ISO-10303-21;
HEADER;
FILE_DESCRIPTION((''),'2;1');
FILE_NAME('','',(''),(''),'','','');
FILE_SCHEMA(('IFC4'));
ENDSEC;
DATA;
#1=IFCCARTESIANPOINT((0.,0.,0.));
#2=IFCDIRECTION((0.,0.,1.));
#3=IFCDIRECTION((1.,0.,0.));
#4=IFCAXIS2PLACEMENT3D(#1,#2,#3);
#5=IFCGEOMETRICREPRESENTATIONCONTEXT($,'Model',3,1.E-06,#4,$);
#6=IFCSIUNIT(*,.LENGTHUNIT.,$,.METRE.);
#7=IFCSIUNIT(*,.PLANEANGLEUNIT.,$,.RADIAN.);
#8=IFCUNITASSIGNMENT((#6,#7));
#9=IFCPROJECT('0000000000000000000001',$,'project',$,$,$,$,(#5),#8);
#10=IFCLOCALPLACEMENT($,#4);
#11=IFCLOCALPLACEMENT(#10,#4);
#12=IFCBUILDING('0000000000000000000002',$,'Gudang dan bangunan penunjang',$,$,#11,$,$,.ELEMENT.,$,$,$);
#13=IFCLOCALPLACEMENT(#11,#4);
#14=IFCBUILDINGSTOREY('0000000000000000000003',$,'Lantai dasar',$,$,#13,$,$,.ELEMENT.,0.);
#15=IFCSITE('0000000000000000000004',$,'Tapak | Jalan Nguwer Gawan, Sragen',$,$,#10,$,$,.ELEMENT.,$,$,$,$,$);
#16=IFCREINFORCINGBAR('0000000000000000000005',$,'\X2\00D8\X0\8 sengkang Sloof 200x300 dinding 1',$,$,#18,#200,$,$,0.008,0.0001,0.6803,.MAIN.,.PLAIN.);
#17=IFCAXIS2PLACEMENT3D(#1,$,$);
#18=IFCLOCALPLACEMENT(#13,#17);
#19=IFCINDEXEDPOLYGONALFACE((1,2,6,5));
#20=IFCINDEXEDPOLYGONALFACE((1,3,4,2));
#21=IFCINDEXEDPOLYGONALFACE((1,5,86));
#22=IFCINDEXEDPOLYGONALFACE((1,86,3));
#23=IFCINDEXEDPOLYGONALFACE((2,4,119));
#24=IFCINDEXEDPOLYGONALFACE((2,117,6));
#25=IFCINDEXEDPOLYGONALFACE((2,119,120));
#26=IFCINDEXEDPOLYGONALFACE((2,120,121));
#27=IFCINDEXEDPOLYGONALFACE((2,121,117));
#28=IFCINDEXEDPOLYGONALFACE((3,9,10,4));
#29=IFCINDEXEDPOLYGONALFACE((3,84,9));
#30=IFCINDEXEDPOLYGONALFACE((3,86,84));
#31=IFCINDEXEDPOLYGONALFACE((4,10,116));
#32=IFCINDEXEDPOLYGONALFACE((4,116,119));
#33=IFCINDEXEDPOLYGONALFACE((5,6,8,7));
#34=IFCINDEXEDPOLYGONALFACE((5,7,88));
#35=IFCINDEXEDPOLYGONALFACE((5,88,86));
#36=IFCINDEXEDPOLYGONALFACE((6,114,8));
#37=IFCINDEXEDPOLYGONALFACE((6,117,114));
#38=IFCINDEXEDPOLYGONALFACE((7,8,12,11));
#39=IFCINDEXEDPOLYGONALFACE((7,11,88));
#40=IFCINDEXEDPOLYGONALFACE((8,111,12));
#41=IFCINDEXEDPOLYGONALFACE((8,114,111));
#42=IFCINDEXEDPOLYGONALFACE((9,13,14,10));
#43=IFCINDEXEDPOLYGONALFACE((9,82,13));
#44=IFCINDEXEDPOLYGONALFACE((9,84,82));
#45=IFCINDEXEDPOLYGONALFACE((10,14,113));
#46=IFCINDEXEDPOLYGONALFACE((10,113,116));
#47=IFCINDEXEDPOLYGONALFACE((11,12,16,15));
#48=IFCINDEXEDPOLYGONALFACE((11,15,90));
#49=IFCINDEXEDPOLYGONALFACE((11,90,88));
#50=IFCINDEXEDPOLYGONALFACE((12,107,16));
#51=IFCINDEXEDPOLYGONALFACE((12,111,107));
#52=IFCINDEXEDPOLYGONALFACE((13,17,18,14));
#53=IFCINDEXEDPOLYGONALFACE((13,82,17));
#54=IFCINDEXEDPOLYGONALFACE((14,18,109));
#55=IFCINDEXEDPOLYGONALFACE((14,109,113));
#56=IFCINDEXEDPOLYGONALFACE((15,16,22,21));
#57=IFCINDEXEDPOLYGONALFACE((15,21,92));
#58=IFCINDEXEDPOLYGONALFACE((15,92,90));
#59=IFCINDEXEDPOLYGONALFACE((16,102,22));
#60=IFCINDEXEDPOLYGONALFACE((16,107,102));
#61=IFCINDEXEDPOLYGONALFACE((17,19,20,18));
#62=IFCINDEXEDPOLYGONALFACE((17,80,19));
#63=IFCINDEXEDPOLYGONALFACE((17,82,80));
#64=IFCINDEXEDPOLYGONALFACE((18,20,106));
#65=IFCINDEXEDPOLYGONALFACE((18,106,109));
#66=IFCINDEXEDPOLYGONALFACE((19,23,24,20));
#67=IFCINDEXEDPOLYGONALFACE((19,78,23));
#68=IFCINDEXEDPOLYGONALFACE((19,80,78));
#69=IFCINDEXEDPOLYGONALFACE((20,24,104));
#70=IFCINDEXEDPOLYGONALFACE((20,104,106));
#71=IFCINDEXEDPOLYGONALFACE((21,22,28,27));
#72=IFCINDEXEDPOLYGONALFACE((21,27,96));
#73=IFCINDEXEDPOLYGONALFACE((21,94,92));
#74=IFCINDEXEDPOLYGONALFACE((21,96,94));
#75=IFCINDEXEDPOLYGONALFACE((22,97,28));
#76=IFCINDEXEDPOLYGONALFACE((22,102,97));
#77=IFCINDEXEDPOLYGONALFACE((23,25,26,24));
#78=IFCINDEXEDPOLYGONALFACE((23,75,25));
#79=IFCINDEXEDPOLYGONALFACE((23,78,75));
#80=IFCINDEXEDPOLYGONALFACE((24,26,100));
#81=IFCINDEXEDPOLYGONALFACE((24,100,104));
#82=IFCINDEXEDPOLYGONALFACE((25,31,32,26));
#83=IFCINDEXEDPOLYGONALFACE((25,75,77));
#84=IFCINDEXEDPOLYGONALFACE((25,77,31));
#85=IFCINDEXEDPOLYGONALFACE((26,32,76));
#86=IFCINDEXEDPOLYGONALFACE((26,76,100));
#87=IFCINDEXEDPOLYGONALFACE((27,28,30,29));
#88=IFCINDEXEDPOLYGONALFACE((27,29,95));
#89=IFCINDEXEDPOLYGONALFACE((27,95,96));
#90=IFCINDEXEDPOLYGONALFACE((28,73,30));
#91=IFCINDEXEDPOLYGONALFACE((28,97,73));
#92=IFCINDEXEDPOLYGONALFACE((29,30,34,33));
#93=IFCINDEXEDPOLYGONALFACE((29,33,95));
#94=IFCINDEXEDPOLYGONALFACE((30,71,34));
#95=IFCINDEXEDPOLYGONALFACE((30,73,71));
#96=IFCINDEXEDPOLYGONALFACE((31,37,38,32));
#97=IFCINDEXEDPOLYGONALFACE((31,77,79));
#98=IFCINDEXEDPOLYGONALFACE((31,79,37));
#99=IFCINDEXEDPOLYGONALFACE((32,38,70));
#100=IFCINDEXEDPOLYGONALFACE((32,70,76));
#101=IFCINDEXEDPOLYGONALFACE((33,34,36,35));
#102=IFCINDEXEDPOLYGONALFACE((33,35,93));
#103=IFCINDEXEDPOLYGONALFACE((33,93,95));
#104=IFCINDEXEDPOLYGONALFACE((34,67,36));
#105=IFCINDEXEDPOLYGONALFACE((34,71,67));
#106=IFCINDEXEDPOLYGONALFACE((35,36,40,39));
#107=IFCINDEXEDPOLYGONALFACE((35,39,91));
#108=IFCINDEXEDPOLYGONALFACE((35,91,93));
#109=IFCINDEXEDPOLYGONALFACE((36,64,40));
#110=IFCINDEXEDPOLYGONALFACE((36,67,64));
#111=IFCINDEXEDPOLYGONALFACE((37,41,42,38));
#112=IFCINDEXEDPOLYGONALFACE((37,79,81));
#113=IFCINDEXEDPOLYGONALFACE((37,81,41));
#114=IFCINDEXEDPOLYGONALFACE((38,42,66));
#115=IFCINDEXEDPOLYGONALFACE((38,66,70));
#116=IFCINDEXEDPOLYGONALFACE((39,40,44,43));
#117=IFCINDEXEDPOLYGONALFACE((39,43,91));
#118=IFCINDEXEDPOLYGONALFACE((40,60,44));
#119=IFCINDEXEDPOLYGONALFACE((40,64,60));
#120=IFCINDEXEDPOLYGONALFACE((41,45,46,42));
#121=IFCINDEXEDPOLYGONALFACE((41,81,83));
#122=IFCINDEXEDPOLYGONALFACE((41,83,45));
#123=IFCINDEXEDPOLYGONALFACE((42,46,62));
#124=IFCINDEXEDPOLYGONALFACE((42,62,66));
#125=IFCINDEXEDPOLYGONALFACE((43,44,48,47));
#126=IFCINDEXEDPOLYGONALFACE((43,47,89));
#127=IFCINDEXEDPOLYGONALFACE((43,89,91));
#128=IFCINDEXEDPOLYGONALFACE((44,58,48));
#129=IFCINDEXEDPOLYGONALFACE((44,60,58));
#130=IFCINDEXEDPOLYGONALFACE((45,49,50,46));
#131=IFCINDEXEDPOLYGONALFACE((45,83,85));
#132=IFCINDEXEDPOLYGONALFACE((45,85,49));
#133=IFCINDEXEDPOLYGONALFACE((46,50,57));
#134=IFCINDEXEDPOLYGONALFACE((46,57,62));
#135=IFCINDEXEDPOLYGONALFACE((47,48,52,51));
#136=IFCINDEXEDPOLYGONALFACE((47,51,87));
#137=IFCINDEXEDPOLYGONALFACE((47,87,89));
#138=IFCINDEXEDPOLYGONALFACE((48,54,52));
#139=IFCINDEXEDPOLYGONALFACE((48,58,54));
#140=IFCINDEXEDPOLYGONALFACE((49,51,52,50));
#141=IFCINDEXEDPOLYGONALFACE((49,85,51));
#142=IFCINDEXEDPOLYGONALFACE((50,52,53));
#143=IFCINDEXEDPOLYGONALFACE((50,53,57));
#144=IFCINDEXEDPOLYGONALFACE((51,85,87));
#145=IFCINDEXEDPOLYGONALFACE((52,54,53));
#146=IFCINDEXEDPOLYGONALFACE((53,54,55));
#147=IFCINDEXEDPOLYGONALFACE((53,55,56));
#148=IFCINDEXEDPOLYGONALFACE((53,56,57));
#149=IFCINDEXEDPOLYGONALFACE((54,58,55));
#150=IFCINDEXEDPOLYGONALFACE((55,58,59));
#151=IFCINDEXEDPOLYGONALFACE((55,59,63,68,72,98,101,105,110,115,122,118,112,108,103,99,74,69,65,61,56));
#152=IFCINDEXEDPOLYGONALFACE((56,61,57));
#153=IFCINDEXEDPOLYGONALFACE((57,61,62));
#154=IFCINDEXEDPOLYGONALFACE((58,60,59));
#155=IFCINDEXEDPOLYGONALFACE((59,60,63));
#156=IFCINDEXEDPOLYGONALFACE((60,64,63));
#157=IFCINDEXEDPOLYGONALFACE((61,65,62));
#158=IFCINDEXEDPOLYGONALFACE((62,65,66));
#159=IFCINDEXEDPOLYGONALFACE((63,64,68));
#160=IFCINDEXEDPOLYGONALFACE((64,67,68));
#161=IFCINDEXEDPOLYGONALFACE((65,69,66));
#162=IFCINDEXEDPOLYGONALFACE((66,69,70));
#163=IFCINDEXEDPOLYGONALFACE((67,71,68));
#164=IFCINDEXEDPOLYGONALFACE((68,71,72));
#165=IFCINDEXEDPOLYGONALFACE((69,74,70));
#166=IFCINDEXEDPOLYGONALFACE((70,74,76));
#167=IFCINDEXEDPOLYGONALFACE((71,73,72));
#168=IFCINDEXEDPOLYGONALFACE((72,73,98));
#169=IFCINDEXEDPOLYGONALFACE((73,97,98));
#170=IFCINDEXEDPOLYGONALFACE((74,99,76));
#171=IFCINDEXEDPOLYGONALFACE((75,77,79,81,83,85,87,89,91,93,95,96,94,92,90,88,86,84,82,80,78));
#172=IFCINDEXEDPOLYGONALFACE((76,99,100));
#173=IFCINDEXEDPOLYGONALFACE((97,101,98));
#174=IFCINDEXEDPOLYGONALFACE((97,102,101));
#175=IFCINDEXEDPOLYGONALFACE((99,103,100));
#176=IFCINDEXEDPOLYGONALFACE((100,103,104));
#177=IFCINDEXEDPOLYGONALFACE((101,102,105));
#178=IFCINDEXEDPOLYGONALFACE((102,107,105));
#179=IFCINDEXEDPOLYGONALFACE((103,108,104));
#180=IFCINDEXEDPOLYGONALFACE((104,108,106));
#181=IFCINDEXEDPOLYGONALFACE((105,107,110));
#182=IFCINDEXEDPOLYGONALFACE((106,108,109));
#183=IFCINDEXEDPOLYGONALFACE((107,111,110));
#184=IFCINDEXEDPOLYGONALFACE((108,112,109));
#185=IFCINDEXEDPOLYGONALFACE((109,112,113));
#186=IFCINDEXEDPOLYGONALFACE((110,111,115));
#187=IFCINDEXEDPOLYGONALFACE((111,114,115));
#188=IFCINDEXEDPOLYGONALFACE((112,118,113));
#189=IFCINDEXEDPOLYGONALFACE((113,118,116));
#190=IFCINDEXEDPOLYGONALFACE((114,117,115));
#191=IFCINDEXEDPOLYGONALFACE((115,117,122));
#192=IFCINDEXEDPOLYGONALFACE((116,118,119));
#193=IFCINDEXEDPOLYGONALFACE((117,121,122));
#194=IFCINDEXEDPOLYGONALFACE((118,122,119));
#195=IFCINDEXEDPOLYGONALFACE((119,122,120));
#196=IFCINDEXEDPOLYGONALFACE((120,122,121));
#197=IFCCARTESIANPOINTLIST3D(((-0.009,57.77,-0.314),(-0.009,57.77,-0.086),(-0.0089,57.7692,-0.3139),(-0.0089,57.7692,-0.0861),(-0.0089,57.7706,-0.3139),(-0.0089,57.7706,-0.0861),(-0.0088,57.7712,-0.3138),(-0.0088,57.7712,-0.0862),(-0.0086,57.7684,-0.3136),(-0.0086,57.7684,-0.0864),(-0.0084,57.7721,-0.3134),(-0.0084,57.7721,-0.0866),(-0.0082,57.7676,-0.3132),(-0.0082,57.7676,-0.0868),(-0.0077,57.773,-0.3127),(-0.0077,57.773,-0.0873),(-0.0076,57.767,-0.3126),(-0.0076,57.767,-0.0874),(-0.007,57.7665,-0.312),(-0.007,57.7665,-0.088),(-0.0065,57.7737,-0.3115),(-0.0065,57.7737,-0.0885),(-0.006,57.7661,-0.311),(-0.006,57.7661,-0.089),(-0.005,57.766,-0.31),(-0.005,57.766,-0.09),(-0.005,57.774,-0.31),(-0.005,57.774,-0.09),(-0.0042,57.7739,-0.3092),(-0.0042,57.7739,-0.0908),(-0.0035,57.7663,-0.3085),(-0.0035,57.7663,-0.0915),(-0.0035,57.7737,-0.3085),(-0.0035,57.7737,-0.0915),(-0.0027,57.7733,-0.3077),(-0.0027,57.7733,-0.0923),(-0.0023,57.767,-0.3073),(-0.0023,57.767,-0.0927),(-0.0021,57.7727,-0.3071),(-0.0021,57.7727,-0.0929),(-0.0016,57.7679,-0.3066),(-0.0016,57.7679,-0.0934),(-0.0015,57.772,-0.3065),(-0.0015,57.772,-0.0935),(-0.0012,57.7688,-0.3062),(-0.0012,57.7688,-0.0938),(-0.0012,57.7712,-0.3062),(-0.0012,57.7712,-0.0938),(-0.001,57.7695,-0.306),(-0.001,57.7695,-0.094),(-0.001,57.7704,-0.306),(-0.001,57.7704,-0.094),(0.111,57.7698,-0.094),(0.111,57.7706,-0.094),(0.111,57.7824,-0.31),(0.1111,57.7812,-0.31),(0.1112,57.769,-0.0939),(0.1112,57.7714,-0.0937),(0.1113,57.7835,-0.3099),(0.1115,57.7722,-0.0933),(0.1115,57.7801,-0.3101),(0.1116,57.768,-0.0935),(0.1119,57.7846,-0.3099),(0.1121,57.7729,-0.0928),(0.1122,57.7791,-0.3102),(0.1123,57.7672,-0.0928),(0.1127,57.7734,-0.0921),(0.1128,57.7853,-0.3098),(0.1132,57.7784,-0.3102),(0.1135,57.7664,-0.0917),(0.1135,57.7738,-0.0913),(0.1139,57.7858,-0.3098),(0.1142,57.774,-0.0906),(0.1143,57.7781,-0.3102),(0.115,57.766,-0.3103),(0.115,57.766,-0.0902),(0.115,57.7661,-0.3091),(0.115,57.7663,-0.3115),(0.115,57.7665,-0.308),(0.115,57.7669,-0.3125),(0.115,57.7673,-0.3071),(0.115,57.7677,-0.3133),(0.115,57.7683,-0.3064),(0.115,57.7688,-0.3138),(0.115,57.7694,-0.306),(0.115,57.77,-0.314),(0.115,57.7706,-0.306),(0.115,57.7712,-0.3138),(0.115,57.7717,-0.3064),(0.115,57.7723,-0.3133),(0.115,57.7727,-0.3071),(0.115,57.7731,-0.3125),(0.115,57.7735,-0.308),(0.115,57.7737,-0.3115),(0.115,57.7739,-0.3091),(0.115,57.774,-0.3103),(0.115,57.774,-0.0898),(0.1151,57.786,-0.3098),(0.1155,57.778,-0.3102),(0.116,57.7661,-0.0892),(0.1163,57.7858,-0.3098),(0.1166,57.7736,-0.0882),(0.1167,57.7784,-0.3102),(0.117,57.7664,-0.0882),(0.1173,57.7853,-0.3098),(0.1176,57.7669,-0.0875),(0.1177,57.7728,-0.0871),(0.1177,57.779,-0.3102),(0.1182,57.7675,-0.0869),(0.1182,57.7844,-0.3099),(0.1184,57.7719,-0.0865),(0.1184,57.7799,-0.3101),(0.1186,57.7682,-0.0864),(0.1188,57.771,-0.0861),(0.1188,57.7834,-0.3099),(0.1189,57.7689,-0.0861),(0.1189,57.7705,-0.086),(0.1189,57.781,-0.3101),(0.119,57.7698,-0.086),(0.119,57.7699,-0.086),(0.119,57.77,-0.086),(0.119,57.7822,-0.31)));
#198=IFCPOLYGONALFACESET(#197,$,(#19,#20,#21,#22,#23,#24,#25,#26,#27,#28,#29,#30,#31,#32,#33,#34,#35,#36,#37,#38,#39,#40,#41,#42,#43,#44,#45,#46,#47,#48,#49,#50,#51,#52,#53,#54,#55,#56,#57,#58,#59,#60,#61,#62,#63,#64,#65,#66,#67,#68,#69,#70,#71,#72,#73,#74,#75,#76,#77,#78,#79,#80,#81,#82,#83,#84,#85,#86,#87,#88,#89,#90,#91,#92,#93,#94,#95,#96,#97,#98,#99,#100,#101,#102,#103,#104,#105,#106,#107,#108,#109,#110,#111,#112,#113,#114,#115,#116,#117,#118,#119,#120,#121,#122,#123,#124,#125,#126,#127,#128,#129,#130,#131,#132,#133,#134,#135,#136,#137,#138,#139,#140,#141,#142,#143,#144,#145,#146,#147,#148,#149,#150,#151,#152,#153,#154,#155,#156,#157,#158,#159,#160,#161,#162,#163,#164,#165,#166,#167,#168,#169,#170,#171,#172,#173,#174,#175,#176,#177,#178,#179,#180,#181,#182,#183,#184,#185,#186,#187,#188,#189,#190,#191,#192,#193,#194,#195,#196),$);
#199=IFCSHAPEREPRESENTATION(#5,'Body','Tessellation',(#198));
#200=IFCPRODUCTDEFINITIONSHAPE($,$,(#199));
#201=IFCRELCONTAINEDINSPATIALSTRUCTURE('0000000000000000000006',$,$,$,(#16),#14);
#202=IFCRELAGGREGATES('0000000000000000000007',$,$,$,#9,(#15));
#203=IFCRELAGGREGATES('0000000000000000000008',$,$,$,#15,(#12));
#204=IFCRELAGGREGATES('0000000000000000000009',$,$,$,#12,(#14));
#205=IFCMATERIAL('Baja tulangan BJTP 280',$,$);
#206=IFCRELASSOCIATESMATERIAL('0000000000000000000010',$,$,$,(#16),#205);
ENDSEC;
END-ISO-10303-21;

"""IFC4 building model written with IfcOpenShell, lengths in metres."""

from ifc_helpers import new_model, entity, si_unit, origin_with_axes, place, context, project, spatial, material, element, save


model = new_model("IFC4")

# Units and contexts
model_context = context("Model", 3, precision=1e-06, world=origin_with_axes())
ifc_project = project(units=[si_unit("LENGTHUNIT", "METRE"), si_unit("PLANEANGLEUNIT", "RADIAN")], contexts=[model_context])

# Site, building, storey
site_placement = place(None, origin_with_axes())
site = spatial("IfcSite", under=ifc_project, at=site_placement, Name="Tapak | Jalan Nguwer Gawan, Sragen", CompositionType="ELEMENT")
building_placement = place(site_placement, origin_with_axes())
building = spatial("IfcBuilding", under=site, at=building_placement, Name="Gudang dan bangunan penunjang", CompositionType="ELEMENT")
storey_placement = place(building_placement, origin_with_axes())
storey = spatial("IfcBuildingStorey", under=building, at=storey_placement, Name="Lantai dasar", CompositionType="ELEMENT", Elevation=0.0)

# Shared definitions
placement = place(None, origin_with_axes())

# Reinforcing bar
ifc_material_1 = material(Name="Baja tulangan BJTP 280")
element("IfcReinforcingBar", 1, at=placement, inside=storey, material=ifc_material_1, Name="Ø8 sengkang Sloof 200x300 dinding 1", BarLength=0.6803, BarSurface="PLAIN", CrossSectionArea=0.0001, NominalDiameter=0.008, PredefinedType="MAIN", context=model_context, shape_type="AdvancedSweptSolid", body=[
    entity("IfcSweptDiskSolid", entity("IfcPolyline", [entity("IfcCartesianPoint", [0.115, 57.77, -0.31]), entity("IfcCartesianPoint", [-0.005, 57.77, -0.31]), entity("IfcCartesianPoint", [-0.005, 57.77, -0.09]), entity("IfcCartesianPoint", [0.115, 57.77, -0.09]), entity("IfcCartesianPoint", [0.115, 57.782, -0.31])]), 0.004),
])

save(model, "model.ifc")
